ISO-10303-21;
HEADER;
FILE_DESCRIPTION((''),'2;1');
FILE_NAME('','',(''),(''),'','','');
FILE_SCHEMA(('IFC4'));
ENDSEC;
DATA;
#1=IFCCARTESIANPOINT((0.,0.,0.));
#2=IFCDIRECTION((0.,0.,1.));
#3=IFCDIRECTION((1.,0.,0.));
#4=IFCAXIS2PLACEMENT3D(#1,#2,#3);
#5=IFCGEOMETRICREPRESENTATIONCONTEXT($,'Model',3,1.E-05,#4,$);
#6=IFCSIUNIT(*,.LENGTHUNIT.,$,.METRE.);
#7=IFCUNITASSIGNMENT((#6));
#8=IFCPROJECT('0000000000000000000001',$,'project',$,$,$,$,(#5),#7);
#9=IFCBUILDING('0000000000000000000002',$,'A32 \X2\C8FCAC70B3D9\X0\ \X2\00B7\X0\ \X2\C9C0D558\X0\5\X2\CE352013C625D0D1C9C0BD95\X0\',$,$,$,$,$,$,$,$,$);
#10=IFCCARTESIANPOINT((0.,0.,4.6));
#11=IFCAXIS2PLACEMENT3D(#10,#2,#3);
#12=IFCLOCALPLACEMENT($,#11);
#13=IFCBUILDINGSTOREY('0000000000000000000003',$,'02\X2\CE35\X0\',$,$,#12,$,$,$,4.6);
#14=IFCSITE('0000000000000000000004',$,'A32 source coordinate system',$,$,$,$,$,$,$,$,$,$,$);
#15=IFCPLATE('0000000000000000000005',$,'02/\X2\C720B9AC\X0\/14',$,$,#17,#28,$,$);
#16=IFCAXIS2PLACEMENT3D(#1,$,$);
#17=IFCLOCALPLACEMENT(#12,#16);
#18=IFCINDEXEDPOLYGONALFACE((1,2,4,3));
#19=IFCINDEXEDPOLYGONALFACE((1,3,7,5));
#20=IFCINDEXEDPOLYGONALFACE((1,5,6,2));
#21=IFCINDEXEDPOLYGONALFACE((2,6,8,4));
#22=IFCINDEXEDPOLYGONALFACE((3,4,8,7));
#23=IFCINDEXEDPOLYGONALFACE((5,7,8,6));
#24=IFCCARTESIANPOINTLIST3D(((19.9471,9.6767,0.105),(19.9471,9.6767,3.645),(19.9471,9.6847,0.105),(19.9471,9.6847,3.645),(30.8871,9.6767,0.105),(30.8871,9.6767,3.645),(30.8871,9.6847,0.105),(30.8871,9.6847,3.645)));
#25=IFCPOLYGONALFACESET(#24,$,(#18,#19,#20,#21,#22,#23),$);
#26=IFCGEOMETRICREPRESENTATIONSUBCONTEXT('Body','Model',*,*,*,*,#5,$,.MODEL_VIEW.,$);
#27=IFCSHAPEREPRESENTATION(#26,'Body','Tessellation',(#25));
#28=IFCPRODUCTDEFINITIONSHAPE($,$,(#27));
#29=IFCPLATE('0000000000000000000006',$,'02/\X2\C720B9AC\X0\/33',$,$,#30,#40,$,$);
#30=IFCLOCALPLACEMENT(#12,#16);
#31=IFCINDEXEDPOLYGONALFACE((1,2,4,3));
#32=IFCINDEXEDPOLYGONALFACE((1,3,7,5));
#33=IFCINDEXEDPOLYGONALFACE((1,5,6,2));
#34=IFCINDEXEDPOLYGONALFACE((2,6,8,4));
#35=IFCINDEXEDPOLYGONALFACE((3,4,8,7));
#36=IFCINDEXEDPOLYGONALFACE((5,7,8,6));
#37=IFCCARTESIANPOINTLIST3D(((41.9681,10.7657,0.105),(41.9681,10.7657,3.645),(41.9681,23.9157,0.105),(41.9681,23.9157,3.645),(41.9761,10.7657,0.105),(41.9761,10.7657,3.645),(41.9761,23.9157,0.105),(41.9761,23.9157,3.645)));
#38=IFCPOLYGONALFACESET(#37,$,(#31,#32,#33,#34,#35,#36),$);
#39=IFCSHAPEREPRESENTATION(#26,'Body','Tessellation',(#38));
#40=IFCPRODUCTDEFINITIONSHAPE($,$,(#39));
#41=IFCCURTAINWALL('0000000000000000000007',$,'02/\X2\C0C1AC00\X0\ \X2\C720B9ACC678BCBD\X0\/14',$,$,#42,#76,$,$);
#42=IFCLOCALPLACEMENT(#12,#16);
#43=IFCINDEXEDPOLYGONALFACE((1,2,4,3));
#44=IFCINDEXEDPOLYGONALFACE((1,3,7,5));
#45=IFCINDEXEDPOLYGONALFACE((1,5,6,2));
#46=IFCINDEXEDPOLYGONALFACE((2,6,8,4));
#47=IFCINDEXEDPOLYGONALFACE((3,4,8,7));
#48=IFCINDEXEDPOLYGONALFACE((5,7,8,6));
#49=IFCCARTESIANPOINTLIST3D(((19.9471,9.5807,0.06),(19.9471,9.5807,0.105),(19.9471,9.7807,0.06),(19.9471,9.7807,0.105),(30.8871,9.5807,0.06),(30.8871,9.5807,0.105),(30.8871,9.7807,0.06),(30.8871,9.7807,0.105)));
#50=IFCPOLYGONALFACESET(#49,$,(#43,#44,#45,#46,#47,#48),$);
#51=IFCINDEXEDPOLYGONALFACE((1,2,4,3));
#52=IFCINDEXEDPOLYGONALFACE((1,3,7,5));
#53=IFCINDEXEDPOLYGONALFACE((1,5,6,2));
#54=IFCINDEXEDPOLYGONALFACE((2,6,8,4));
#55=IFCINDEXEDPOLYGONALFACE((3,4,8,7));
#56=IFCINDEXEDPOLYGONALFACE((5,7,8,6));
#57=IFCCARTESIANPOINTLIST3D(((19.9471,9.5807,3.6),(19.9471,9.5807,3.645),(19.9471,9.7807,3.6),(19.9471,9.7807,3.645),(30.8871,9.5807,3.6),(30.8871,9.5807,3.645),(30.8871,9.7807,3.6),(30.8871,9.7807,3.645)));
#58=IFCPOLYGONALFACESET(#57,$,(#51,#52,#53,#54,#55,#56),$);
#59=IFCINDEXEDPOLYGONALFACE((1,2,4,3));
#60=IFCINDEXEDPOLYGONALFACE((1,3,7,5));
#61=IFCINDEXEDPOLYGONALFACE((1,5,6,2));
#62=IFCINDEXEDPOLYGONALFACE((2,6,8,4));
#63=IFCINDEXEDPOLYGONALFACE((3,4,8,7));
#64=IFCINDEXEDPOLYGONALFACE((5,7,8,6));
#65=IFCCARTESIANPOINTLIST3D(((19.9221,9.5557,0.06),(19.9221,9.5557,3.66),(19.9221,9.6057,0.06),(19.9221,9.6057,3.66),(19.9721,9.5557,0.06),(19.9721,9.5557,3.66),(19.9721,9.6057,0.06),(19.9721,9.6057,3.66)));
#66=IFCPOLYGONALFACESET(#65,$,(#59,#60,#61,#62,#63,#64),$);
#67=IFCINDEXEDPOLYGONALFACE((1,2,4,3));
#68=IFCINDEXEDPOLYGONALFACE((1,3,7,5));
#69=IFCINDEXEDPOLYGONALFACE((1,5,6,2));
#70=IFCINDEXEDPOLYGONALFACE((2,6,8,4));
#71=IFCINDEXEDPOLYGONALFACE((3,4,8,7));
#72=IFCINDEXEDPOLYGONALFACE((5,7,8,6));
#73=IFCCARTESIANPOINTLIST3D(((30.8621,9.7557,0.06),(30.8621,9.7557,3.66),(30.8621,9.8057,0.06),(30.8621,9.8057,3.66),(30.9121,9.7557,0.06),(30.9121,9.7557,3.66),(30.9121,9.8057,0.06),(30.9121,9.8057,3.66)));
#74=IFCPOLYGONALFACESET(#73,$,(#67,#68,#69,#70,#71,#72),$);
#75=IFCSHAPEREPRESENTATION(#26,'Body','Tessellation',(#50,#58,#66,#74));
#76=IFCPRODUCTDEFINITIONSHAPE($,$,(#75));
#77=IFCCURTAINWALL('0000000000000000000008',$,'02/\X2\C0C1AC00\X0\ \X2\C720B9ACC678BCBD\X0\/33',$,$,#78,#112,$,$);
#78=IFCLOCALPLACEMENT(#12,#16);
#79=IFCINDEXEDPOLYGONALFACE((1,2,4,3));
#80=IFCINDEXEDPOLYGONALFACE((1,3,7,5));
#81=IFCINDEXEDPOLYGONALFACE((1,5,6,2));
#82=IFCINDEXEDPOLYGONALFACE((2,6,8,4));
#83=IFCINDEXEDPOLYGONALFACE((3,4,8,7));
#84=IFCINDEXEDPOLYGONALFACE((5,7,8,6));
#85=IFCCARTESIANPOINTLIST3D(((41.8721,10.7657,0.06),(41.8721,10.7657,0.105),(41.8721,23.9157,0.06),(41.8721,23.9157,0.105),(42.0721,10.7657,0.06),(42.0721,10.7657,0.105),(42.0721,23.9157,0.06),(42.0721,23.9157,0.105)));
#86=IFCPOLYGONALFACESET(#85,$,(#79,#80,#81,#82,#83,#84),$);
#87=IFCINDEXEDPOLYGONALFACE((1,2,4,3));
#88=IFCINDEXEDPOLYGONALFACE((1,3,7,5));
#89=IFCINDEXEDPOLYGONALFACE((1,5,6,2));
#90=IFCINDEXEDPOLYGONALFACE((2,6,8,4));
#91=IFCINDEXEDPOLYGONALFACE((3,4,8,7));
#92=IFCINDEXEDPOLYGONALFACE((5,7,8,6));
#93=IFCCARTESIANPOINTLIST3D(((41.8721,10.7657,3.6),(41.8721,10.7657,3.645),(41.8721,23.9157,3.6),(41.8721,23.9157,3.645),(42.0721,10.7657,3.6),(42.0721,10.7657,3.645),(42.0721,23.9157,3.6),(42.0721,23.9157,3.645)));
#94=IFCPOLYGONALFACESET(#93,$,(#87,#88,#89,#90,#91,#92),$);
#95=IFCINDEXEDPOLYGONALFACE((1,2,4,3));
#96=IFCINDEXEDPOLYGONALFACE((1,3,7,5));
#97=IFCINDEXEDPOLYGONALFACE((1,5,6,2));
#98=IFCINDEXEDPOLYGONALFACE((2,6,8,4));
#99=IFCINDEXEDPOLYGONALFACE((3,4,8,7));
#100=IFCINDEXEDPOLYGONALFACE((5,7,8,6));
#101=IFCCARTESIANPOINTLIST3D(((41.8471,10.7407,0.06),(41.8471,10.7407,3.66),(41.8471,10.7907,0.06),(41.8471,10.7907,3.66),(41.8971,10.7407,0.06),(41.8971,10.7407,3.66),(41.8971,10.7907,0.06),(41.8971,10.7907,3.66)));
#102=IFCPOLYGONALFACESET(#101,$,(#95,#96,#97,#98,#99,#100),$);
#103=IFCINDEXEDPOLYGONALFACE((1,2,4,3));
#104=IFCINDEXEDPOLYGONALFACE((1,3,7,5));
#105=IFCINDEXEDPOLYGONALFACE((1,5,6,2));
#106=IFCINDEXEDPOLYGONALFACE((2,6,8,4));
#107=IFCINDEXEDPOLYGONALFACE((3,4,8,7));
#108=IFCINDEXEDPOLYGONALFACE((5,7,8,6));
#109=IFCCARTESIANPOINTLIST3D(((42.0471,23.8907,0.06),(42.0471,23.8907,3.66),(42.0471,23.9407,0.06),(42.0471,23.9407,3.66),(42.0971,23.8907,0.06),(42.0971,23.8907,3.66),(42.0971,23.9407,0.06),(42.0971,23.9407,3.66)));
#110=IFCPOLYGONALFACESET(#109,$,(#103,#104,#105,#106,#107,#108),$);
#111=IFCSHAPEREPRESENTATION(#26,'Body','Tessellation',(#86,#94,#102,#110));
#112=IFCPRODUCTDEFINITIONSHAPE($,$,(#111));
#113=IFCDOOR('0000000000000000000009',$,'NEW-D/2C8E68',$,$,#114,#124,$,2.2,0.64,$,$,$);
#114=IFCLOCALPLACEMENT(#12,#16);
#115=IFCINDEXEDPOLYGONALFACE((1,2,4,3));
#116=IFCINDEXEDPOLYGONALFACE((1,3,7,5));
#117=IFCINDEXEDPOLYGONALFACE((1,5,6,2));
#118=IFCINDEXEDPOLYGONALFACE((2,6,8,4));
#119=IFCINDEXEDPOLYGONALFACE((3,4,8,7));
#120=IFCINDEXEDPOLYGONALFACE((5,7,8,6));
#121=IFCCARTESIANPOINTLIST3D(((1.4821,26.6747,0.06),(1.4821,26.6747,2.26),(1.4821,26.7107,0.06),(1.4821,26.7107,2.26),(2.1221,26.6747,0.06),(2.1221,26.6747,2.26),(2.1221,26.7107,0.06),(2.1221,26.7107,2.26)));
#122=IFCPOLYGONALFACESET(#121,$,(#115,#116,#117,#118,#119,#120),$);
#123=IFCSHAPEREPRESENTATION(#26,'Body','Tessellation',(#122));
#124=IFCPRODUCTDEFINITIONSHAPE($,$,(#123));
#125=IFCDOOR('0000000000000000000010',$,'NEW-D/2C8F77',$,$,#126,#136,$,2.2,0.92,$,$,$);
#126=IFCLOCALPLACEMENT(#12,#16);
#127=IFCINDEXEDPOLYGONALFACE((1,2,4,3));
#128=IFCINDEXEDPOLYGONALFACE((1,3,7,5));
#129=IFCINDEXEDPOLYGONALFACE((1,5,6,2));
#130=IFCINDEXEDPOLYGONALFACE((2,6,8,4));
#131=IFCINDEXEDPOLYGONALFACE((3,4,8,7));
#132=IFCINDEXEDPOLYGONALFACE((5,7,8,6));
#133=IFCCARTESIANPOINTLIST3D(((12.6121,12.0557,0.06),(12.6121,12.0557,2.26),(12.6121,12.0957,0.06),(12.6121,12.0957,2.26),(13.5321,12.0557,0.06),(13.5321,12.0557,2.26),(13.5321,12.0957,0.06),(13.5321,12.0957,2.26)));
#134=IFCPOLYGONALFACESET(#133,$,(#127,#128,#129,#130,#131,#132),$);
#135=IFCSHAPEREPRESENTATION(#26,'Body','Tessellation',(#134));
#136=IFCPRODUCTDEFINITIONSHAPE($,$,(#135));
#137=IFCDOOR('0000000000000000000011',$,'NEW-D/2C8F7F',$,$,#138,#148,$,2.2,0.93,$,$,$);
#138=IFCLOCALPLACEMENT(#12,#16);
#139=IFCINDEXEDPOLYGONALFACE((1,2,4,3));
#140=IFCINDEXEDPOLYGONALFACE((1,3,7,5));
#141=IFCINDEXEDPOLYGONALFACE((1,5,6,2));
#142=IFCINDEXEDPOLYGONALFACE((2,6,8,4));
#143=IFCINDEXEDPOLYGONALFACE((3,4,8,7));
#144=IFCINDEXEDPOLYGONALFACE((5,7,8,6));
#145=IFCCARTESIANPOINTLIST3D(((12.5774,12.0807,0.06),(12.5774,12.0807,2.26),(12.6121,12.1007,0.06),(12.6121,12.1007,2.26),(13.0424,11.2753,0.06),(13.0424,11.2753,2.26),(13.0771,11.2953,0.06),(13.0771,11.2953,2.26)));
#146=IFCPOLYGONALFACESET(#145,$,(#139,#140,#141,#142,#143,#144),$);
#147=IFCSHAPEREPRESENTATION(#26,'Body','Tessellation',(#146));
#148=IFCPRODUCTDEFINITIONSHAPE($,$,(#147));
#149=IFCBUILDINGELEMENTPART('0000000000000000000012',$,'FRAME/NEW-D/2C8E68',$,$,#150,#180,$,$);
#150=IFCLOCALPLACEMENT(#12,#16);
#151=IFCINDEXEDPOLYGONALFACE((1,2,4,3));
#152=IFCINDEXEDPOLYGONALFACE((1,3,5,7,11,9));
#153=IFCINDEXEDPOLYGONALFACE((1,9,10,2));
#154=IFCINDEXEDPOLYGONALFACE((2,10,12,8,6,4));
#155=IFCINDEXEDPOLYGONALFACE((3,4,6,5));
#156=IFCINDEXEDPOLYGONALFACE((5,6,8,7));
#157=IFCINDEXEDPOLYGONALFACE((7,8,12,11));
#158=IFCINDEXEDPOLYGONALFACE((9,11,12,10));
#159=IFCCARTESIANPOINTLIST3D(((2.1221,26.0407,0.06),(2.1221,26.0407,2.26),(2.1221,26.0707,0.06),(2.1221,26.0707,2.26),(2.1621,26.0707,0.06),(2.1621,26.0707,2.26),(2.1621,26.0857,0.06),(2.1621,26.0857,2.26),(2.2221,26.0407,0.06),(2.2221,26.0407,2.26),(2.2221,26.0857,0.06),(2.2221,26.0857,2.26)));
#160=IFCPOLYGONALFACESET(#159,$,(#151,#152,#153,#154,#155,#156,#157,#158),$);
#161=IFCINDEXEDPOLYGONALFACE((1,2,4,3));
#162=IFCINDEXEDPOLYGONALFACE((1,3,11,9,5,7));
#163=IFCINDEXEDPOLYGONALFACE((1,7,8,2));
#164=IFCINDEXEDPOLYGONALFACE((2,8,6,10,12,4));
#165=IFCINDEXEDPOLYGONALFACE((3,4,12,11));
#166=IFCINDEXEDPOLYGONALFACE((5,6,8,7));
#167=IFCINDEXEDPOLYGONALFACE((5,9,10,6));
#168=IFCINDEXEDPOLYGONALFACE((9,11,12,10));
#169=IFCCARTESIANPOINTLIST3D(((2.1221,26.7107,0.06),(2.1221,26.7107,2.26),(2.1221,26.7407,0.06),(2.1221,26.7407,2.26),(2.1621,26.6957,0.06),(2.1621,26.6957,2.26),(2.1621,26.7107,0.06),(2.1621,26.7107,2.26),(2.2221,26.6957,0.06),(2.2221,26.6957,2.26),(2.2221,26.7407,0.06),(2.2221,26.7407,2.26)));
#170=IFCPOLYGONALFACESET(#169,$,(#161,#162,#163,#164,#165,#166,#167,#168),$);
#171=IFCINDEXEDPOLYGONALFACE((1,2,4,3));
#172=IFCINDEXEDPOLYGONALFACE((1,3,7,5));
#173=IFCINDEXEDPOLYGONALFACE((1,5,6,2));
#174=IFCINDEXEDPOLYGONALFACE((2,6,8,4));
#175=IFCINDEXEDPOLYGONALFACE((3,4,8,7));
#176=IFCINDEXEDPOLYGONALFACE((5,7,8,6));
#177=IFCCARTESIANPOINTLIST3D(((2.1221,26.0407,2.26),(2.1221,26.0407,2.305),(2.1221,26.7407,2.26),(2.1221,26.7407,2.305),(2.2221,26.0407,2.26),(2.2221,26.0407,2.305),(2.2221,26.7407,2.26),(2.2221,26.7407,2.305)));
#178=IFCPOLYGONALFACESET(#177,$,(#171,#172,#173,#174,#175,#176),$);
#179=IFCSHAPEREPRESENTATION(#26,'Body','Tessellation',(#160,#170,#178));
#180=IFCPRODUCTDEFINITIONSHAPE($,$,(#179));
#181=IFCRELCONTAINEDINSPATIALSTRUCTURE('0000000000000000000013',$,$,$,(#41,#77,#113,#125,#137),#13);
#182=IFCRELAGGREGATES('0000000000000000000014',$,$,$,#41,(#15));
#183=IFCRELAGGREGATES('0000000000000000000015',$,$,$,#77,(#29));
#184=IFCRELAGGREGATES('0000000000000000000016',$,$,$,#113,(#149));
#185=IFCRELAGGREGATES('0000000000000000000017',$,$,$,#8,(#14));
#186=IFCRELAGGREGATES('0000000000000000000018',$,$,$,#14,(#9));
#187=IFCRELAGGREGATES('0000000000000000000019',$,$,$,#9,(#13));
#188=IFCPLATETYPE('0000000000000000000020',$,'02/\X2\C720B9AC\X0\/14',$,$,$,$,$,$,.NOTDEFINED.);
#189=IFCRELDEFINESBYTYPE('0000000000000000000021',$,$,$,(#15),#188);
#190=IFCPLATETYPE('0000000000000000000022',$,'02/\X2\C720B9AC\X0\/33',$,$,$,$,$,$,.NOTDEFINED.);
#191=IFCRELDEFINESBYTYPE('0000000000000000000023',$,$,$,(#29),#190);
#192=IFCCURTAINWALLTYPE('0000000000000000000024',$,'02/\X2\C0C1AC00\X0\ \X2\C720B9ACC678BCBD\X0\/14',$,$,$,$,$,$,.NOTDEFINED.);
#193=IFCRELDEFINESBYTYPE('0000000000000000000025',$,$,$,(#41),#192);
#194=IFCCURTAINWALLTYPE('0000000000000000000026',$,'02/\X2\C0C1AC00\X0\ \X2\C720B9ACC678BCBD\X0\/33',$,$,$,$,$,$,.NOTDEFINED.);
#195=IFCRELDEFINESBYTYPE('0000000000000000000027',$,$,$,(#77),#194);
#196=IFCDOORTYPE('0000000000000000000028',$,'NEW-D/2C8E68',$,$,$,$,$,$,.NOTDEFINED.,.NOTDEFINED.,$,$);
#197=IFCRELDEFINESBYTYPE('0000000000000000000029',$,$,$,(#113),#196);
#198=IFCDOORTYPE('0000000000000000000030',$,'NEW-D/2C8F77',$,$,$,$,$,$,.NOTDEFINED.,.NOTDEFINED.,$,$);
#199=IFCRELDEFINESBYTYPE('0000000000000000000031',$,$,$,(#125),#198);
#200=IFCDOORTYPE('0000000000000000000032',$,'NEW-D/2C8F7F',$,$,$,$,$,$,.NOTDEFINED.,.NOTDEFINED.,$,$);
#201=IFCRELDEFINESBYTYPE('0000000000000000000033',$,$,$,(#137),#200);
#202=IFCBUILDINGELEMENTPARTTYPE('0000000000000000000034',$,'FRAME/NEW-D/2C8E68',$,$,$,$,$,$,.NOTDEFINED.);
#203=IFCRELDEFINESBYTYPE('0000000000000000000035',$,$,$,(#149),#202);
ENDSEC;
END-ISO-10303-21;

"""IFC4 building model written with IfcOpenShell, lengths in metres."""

from ifc_helpers import new_model, si_unit, frame, origin, origin_with_axes, place, context, subcontext, project, spatial, polyline, outline, extrude, source, transform, mapped, type_object, type_shapes, element, aggregate, save


model = new_model("IFC4")

# Units and contexts
model_context = context("Model", 3, precision=1e-05, world=origin_with_axes())
body_context = subcontext(model_context, "Body", "Model", "MODEL_VIEW")
ifc_project = project(units=[si_unit("LENGTHUNIT", "METRE")], contexts=[model_context])

# Plates
storey_placement = place(None, frame((0.0, 0.0, 4.6), z_axis=(0.0, 0.0, 1.0), x_axis=(1.0, 0.0, 0.0)))
plate_type_1 = type_object("IfcPlateType", Name="02/유리/14", PredefinedType="NOTDEFINED")
shared_shape_1 = source(origin(), body_context, "Body", "SweptSolid", [
    extrude(outline(polyline([(30.8871, 9.6767), (19.9471, 9.6767), (19.9471, 9.6847), (30.8871, 9.6847), (30.8871, 9.6767)])), frame((0.0, 0.0, 0.105)), (0.0, 0.0, 1.0), 3.54),
])
type_shapes(plate_type_1, [shared_shape_1])
curtain_wall_1_placement = place(storey_placement, origin_with_axes())
plate_1_placement = place(curtain_wall_1_placement, origin_with_axes())
plate_1 = element("IfcPlate", 1, at=plate_1_placement, type_object=plate_type_1, Name="02/유리/14", context=body_context, shape_type="MappedRepresentation", body=[
    mapped(shared_shape_1, transform((0.0, 0.0, 0.0), scale=1.0)),
])
plate_type_2 = type_object("IfcPlateType", Name="02/유리/33", PredefinedType="NOTDEFINED")
shared_shape_2 = source(origin(), body_context, "Body", "SweptSolid", [
    extrude(outline(polyline([(41.9761, 10.7657), (41.9681, 10.7657), (41.9681, 23.9157), (41.9761, 23.9157), (41.9761, 10.7657)])), frame((0.0, 0.0, 0.105)), (0.0, 0.0, 1.0), 3.54),
])
type_shapes(plate_type_2, [shared_shape_2])
curtain_wall_2_placement = place(storey_placement, origin_with_axes())
plate_2_placement = place(curtain_wall_2_placement, origin_with_axes())
plate_2 = element("IfcPlate", 2, at=plate_2_placement, type_object=plate_type_2, Name="02/유리/33", context=body_context, shape_type="MappedRepresentation", body=[
    mapped(shared_shape_2, transform((0.0, 0.0, 0.0), scale=1.0)),
])

# Site, building, storey
site = spatial("IfcSite", under=ifc_project, Name="A32 source coordinate system")
building = spatial("IfcBuilding", under=site, Name="A32 주거동 · 지하5층–옥탑지붕")
storey = spatial("IfcBuildingStorey", under=building, at=storey_placement, Name="02층", Elevation=4.6)

# Curtain walls
curtain_wall_type_1 = type_object("IfcCurtainWallType", Name="02/상가 유리외벽/14", PredefinedType="NOTDEFINED")
shared_shape_3 = source(origin(), body_context, "Body", "SweptSolid", [
    extrude(outline(polyline([(30.8871, 9.5807), (19.9471, 9.5807), (19.9471, 9.7807), (30.8871, 9.7807), (30.8871, 9.5807)])), frame((0.0, 0.0, 0.06)), (0.0, 0.0, 1.0), 0.045),
    extrude(outline(polyline([(30.8871, 9.5807), (30.8871, 9.7807), (19.9471, 9.7807), (19.9471, 9.5807), (30.8871, 9.5807)])), frame((0.0, 0.0, 3.6)), (0.0, 0.0, 1.0), 0.045),
    extrude(outline(polyline([(19.9721, 9.5557), (19.9721, 9.6057), (19.9221, 9.6057), (19.9221, 9.5557), (19.9721, 9.5557)])), frame((0.0, 0.0, 0.06)), (0.0, 0.0, 1.0), 3.6),
    extrude(outline(polyline([(30.9121, 9.7557), (30.9121, 9.8057), (30.8621, 9.8057), (30.8621, 9.7557), (30.9121, 9.7557)])), frame((0.0, 0.0, 0.06)), (0.0, 0.0, 1.0), 3.6),
])
type_shapes(curtain_wall_type_1, [shared_shape_3])
curtain_wall_1 = element("IfcCurtainWall", 3, at=curtain_wall_1_placement, inside=storey, type_object=curtain_wall_type_1, Name="02/상가 유리외벽/14", context=body_context, shape_type="MappedRepresentation", body=[
    mapped(shared_shape_3, transform((0.0, 0.0, 0.0), scale=1.0)),
])
aggregate(curtain_wall_1, [plate_1])
curtain_wall_type_2 = type_object("IfcCurtainWallType", Name="02/상가 유리외벽/33", PredefinedType="NOTDEFINED")
shared_shape_4 = source(origin(), body_context, "Body", "SweptSolid", [
    extrude(outline(polyline([(42.0721, 10.7657), (41.8721, 10.7657), (41.8721, 23.9157), (42.0721, 23.9157), (42.0721, 10.7657)])), frame((0.0, 0.0, 0.06)), (0.0, 0.0, 1.0), 0.045),
    extrude(outline(polyline([(42.0721, 10.7657), (42.0721, 23.9157), (41.8721, 23.9157), (41.8721, 10.7657), (42.0721, 10.7657)])), frame((0.0, 0.0, 3.6)), (0.0, 0.0, 1.0), 0.045),
    extrude(outline(polyline([(41.8971, 10.7407), (41.8971, 10.7907), (41.8471, 10.7907), (41.8471, 10.7407), (41.8971, 10.7407)])), frame((0.0, 0.0, 0.06)), (0.0, 0.0, 1.0), 3.6),
    extrude(outline(polyline([(42.0971, 23.8907), (42.0971, 23.9407), (42.0471, 23.9407), (42.0471, 23.8907), (42.0971, 23.8907)])), frame((0.0, 0.0, 0.06)), (0.0, 0.0, 1.0), 3.6),
])
type_shapes(curtain_wall_type_2, [shared_shape_4])
curtain_wall_2 = element("IfcCurtainWall", 4, at=curtain_wall_2_placement, inside=storey, type_object=curtain_wall_type_2, Name="02/상가 유리외벽/33", context=body_context, shape_type="MappedRepresentation", body=[
    mapped(shared_shape_4, transform((0.0, 0.0, 0.0), scale=1.0)),
])
aggregate(curtain_wall_2, [plate_2])

# Door
door_type_1 = type_object("IfcDoorType", Name="NEW-D/2C8E68", OperationType="NOTDEFINED", PredefinedType="NOTDEFINED")
shared_shape_5 = source(origin(), body_context, "Body", "SweptSolid", [
    extrude(outline(polyline([(2.1221, 26.7107), (2.1221, 26.6747), (1.4821, 26.6747), (1.4821, 26.7107), (2.1221, 26.7107)])), frame((0.0, 0.0, 0.06)), (0.0, 0.0, 1.0), 2.2),
])
type_shapes(door_type_1, [shared_shape_5])
door_1_placement = place(storey_placement, origin_with_axes())
door_1 = element("IfcDoor", 5, at=door_1_placement, inside=storey, type_object=door_type_1, Name="NEW-D/2C8E68", OverallHeight=2.2, OverallWidth=0.64, context=body_context, shape_type="MappedRepresentation", body=[
    mapped(shared_shape_5, transform((0.0, 0.0, 0.0), scale=1.0)),
])

# Doors
door_type_2 = type_object("IfcDoorType", Name="NEW-D/2C8F77", OperationType="NOTDEFINED", PredefinedType="NOTDEFINED")
shared_shape_6 = source(origin(), body_context, "Body", "SweptSolid", [
    extrude(outline(polyline([(13.5321, 12.0557), (12.6121, 12.0557), (12.6121, 12.0957), (13.5321, 12.0957), (13.5321, 12.0557)])), frame((0.0, 0.0, 0.06)), (0.0, 0.0, 1.0), 2.2),
])
type_shapes(door_type_2, [shared_shape_6])
door_2_placement = place(storey_placement, origin_with_axes())
element("IfcDoor", 6, at=door_2_placement, inside=storey, type_object=door_type_2, Name="NEW-D/2C8F77", OverallHeight=2.2, OverallWidth=0.92, context=body_context, shape_type="MappedRepresentation", body=[
    mapped(shared_shape_6, transform((0.0, 0.0, 0.0), scale=1.0)),
])
door_type_3 = type_object("IfcDoorType", Name="NEW-D/2C8F7F", OperationType="NOTDEFINED", PredefinedType="NOTDEFINED")
shared_shape_7 = source(origin(), body_context, "Body", "SweptSolid", [
    extrude(outline(polyline([(13.0424, 11.2753), (12.5774, 12.0807), (12.6121, 12.1007), (13.0771, 11.2953), (13.0424, 11.2753)])), frame((0.0, 0.0, 0.06)), (0.0, 0.0, 1.0), 2.2),
])
type_shapes(door_type_3, [shared_shape_7])
door_3_placement = place(storey_placement, origin_with_axes())
element("IfcDoor", 7, at=door_3_placement, inside=storey, type_object=door_type_3, Name="NEW-D/2C8F7F", OverallHeight=2.2, OverallWidth=0.93, context=body_context, shape_type="MappedRepresentation", body=[
    mapped(shared_shape_7, transform((0.0, 0.0, 0.0), scale=1.0)),
])

# Building element part
building_element_part_type_1 = type_object("IfcBuildingElementPartType", Name="FRAME/NEW-D/2C8E68", PredefinedType="NOTDEFINED")
shared_shape_8 = source(origin(), body_context, "Body", "SweptSolid", [
    extrude(outline(polyline([(2.1621, 26.0707), (2.1621, 26.0857), (2.2221, 26.0857), (2.2221, 26.0407), (2.1221, 26.0407), (2.1221, 26.0707), (2.1621, 26.0707)])), frame((0.0, 0.0, 0.06)), (0.0, 0.0, 1.0), 2.2),
    extrude(outline(polyline([(2.2221, 26.6957), (2.1621, 26.6957), (2.1621, 26.7107), (2.1221, 26.7107), (2.1221, 26.7407), (2.2221, 26.7407), (2.2221, 26.6957)])), frame((0.0, 0.0, 0.06)), (0.0, 0.0, 1.0), 2.2),
    extrude(outline(polyline([(2.2221, 26.0407), (2.2221, 26.7407), (2.1221, 26.7407), (2.1221, 26.0407), (2.2221, 26.0407)])), frame((0.0, 0.0, 2.26)), (0.0, 0.0, 1.0), 0.045),
])
type_shapes(building_element_part_type_1, [shared_shape_8])
building_element_part_1_placement = place(door_1_placement, origin_with_axes())
building_element_part_1 = element("IfcBuildingElementPart", 8, at=building_element_part_1_placement, type_object=building_element_part_type_1, Name="FRAME/NEW-D/2C8E68", context=body_context, shape_type="MappedRepresentation", body=[
    mapped(shared_shape_8, transform((0.0, 0.0, 0.0), scale=1.0)),
])
aggregate(door_1, [building_element_part_1])

save(model, "model.ifc")
